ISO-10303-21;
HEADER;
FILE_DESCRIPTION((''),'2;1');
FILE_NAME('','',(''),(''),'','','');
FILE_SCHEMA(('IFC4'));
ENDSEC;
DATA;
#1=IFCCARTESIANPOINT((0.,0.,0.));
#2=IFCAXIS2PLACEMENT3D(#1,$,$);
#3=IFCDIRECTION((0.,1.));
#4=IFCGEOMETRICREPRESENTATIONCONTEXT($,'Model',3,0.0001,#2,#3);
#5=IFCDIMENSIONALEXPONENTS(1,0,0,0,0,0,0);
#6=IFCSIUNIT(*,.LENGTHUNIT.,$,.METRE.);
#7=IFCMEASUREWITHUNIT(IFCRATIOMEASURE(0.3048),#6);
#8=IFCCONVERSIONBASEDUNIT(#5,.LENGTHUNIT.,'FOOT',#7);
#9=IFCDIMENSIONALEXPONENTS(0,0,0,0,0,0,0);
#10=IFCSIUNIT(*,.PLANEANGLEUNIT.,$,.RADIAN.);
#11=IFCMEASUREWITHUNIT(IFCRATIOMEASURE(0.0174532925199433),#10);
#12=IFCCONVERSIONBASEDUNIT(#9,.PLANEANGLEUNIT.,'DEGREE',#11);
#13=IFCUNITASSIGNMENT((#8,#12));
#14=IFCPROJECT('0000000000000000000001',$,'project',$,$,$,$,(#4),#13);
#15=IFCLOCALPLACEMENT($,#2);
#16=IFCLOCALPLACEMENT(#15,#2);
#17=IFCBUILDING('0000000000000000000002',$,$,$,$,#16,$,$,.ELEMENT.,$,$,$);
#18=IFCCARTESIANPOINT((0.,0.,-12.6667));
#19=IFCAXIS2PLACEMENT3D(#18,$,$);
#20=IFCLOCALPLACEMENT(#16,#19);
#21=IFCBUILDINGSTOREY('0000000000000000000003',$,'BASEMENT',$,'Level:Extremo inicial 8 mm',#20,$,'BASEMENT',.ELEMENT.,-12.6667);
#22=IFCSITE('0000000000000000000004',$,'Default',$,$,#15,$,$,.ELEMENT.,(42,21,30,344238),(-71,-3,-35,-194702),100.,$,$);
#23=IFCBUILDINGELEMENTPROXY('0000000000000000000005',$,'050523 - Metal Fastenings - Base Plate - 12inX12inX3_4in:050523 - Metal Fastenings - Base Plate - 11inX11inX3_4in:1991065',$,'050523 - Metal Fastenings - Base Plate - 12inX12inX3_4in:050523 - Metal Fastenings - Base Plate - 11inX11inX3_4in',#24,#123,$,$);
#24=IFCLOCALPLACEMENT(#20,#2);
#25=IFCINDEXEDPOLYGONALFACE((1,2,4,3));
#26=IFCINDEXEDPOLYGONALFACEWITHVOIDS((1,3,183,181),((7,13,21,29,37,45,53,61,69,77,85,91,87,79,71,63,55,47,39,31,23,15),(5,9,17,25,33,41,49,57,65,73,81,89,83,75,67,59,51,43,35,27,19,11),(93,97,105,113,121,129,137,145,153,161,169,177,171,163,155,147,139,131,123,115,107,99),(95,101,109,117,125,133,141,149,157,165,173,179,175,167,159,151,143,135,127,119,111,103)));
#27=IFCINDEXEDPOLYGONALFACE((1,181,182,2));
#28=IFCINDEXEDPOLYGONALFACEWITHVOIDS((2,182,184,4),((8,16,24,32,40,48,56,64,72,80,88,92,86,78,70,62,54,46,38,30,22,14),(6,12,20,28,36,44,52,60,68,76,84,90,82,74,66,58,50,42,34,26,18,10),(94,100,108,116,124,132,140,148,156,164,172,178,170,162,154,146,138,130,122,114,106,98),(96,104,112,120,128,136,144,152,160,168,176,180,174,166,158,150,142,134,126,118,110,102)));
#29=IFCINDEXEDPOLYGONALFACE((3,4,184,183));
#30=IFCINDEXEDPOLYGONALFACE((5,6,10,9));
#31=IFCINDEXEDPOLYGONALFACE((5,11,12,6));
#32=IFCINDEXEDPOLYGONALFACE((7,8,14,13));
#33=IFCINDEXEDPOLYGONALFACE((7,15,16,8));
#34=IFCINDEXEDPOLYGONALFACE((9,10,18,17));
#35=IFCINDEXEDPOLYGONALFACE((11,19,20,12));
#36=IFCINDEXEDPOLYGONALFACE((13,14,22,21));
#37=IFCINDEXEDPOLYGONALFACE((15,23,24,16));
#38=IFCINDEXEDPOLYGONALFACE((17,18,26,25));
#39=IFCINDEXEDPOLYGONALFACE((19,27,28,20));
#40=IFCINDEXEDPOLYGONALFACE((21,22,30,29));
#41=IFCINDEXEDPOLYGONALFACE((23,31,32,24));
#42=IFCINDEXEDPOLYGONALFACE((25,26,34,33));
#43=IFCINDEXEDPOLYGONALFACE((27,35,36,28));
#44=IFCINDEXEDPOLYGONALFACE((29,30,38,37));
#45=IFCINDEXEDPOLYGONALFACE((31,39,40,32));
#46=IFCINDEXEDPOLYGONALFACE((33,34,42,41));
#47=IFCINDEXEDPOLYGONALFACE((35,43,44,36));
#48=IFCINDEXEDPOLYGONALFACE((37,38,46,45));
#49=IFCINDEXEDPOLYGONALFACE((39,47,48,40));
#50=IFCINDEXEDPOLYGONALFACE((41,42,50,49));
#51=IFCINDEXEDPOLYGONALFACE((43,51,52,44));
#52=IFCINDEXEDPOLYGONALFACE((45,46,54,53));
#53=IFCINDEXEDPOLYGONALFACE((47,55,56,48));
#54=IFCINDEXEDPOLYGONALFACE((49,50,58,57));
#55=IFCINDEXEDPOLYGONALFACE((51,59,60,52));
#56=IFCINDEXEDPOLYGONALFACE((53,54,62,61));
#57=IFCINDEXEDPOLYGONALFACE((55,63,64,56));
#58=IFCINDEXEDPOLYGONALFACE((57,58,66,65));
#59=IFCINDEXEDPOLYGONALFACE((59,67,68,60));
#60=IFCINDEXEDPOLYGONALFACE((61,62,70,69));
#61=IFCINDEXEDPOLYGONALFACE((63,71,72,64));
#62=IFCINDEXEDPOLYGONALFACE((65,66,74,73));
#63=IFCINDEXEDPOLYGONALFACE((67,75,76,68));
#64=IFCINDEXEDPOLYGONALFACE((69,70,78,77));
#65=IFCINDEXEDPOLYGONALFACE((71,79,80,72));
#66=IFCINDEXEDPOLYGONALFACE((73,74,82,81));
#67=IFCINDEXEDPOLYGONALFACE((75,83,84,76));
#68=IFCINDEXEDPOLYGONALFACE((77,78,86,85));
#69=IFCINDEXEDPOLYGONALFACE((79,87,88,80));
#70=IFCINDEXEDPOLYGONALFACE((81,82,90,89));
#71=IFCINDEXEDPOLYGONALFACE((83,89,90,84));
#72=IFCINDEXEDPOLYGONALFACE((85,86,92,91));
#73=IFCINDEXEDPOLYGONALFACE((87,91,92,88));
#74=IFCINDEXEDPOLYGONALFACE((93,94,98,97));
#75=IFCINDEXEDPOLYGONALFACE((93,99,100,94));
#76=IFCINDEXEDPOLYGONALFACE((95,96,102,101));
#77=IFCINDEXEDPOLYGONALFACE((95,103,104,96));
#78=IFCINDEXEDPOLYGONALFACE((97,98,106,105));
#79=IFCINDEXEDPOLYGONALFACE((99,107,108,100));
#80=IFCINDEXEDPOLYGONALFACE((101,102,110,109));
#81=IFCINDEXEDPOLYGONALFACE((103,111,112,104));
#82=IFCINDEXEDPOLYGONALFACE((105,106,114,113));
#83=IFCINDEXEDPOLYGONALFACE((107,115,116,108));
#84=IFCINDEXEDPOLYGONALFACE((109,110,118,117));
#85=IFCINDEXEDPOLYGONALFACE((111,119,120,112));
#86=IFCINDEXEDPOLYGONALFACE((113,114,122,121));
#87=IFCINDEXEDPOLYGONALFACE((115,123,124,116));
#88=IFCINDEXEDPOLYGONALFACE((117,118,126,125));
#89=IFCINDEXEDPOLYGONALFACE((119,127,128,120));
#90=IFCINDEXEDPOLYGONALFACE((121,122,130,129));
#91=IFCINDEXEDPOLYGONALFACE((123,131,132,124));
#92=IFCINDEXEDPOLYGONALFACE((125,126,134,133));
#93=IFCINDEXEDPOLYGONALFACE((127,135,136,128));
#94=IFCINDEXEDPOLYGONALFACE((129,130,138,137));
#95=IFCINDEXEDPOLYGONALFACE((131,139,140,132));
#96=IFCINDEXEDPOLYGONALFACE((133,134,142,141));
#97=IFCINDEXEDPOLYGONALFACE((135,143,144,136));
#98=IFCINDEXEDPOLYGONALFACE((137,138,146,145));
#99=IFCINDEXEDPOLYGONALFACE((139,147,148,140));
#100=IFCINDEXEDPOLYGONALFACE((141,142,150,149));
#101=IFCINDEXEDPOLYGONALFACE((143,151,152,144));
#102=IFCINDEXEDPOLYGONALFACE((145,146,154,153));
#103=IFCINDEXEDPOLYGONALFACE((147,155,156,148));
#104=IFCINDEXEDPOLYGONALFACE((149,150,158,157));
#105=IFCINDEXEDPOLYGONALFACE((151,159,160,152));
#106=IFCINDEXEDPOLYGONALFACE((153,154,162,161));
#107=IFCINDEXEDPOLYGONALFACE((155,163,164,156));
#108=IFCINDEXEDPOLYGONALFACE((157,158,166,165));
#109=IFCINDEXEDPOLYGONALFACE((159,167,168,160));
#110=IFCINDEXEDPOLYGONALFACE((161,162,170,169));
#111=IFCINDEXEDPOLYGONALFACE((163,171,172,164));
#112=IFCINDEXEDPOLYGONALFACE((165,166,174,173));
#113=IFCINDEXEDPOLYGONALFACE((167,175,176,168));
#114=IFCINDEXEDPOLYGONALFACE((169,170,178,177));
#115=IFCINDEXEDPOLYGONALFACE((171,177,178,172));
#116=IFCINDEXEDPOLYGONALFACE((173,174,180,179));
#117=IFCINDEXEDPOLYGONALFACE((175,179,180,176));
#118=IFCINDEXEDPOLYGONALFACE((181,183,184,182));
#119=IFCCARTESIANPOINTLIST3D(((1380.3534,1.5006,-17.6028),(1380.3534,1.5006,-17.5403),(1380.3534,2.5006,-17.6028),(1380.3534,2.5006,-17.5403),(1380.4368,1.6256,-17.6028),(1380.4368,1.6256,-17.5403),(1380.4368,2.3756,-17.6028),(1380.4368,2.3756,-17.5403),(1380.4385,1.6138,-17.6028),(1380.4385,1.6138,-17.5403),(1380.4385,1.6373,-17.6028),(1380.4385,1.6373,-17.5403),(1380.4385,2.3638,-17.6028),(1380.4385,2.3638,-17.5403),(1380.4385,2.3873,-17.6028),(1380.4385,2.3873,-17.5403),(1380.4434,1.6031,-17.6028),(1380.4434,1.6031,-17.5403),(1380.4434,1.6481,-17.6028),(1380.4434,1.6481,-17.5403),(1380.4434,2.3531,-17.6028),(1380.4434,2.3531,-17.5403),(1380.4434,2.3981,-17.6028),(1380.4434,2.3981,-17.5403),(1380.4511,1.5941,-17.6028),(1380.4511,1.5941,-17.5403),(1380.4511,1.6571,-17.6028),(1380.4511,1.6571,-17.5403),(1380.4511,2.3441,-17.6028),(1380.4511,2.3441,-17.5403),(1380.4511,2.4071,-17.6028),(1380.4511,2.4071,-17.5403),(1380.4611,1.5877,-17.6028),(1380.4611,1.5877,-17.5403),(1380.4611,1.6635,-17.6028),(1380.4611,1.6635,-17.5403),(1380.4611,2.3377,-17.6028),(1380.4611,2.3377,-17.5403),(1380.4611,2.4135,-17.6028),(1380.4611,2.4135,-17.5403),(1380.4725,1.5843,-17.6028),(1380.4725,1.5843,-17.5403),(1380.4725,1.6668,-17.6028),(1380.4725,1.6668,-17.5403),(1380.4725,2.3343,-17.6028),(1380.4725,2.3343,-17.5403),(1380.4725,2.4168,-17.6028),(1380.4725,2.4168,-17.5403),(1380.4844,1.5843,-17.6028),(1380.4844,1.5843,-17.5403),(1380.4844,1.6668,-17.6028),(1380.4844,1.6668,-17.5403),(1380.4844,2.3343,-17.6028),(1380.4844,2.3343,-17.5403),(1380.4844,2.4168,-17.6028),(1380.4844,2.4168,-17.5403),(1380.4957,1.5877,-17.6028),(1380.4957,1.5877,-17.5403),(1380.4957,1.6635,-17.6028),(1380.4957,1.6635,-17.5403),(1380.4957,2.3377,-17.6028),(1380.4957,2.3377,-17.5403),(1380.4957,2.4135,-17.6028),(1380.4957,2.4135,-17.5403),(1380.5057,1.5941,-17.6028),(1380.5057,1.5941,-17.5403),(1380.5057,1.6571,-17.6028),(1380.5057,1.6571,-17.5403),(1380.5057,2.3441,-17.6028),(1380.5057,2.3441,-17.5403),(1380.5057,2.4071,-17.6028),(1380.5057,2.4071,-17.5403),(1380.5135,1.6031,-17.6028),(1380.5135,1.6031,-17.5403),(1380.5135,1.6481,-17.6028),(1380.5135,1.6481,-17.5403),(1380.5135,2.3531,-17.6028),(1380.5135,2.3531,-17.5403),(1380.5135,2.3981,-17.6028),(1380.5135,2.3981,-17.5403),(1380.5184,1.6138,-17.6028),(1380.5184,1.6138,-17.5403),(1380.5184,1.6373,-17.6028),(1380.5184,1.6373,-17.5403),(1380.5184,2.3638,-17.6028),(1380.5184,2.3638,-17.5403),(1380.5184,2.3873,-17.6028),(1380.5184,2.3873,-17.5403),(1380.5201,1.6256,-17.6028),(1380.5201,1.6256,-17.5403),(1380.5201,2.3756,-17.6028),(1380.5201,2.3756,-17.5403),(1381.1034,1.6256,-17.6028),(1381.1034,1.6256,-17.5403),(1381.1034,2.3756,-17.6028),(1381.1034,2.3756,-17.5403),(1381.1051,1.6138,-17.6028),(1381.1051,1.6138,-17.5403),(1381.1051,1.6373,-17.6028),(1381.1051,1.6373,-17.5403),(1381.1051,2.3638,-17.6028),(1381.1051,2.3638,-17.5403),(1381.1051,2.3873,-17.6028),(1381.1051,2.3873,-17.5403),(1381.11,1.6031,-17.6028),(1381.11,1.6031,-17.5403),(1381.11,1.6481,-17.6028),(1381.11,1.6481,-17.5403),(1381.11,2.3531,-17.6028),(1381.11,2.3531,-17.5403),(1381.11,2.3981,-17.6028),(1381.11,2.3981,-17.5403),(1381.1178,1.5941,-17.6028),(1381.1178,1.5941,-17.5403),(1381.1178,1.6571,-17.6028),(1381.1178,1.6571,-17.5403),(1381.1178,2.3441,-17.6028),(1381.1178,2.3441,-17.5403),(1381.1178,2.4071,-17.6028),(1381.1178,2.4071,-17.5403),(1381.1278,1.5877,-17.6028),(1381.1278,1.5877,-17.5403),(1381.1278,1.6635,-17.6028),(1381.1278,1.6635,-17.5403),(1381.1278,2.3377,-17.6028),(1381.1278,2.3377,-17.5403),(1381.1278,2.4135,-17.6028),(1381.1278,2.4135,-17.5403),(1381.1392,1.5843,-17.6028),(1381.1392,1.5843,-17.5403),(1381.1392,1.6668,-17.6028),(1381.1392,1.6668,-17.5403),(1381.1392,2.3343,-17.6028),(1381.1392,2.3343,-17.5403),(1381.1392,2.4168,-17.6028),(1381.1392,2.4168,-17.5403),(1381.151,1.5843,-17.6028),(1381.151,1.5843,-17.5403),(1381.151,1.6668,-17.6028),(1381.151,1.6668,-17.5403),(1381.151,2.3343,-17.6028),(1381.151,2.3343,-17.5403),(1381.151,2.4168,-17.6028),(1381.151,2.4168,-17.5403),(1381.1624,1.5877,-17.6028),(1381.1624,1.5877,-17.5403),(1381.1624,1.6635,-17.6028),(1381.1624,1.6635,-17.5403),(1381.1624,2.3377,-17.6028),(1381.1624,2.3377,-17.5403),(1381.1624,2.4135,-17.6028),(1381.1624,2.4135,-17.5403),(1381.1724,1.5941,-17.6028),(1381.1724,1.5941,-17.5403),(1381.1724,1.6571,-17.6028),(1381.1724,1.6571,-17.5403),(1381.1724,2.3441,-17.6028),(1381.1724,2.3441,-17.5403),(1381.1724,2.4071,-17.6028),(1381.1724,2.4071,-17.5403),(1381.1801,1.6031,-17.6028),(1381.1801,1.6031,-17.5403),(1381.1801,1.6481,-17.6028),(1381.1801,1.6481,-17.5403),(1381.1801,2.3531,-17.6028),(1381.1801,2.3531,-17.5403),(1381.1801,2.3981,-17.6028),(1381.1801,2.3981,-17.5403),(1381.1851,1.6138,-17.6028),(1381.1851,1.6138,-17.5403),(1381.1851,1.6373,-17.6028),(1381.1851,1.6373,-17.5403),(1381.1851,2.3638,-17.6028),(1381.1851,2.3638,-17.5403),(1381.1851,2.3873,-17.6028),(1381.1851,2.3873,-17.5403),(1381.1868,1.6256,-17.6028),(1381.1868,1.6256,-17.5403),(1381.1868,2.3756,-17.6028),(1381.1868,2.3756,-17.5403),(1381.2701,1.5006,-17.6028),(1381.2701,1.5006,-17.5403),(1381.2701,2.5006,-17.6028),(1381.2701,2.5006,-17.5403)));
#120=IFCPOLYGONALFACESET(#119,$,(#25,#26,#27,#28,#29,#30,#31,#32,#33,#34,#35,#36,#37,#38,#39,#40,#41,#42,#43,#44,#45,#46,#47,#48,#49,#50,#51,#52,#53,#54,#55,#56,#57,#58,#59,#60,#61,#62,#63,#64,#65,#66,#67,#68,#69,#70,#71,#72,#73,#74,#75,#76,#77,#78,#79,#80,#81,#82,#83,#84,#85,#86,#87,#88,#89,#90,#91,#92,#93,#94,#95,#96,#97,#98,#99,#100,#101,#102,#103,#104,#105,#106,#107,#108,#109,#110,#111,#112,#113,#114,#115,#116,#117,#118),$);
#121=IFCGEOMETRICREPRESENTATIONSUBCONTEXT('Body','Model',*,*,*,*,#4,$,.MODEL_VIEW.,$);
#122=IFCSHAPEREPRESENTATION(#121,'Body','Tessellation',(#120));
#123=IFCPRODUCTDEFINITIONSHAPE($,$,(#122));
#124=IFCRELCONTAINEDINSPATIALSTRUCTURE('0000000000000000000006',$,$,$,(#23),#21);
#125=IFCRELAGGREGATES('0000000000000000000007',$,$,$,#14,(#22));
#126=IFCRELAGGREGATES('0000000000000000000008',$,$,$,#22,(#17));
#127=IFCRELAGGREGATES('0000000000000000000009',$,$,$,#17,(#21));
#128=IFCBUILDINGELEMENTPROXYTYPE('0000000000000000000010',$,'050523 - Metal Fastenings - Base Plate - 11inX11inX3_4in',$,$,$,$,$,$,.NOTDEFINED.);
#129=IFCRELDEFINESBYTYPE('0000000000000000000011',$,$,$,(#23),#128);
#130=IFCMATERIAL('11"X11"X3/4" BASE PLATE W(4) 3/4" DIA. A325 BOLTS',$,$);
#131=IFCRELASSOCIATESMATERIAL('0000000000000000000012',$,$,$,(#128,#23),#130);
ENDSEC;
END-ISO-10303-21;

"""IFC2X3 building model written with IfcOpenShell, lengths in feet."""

from ifc_helpers import new_model, entity, si_unit, converted_unit, direction, frame, frame_2d, origin, place, context, subcontext, project, spatial, polyline, circle_curve, parameter, trimmed, segment, composite_curve, outline, extrude, source, transform, mapped, material, type_object, type_shapes, element, save


model = new_model("IFC2X3")

# Units and contexts
model_context = context("Model", 3, precision=0.0001, world=origin(), true_north=direction((0.0, 1.0)))
body_context = subcontext(model_context, "Body", "Model", "MODEL_VIEW")
ifc_project = project(units=[converted_unit("LENGTHUNIT", "FOOT", entity("IfcRatioMeasure", 0.3048), si_unit("LENGTHUNIT", "METRE"), dimensions=[1, 0, 0, 0, 0, 0, 0]), converted_unit("PLANEANGLEUNIT", "DEGREE", entity("IfcRatioMeasure", 0.0174532925199433), si_unit("PLANEANGLEUNIT", "RADIAN"), dimensions=[0, 0, 0, 0, 0, 0, 0])], contexts=[model_context])

# Site, building, storey
site_placement = place(None, origin())
site = spatial("IfcSite", under=ifc_project, at=site_placement, Name="Default", CompositionType="ELEMENT", RefLatitude=(42, 21, 30, 344238), RefLongitude=(-71, -3, -35, -194702), RefElevation=100.0)
building_placement = place(site_placement, origin())
building = spatial("IfcBuilding", under=site, at=building_placement, CompositionType="ELEMENT")
storey_placement = place(building_placement, frame((0.0, 0.0, -12.6667)))
storey = spatial("IfcBuildingStorey", under=building, at=storey_placement, Name="BASEMENT", ObjectType="Level:Extremo inicial 8 mm", LongName="BASEMENT", CompositionType="ELEMENT", Elevation=-12.6667)

# Building element proxy
ifc_material_1 = material(Name="11\"X11\"X3/4\" BASE PLATE W(4) 3/4\" DIA. A325 BOLTS")
building_element_proxy_type_1 = type_object("IfcBuildingElementProxyType", Name="050523 - Metal Fastenings - Base Plate - 11inX11inX3_4in", PredefinedType="NOTDEFINED", material=ifc_material_1)
shared_shape_1 = source(origin(), body_context, "Body", "SweptSolid", [
    extrude(outline(polyline([(-0.4583, -0.5), (0.4583, -0.5), (0.4583, 0.5), (-0.4583, 0.5), (-0.4583, -0.5)]), holes=[composite_curve([segment(trimmed(circle_curve(frame_2d((-0.3333, -0.375), x_axis=(-1.0, 0.0)), 0.0417), [parameter(180.0)], [parameter(0.0)], True, "PARAMETER"), False, "CONTINUOUS"), segment(trimmed(circle_curve(frame_2d((-0.3333, -0.375), x_axis=(-1.0, 0.0)), 0.0417), [parameter(0.0)], [parameter(180.0)], True, "PARAMETER"), False, "CONTINUOUS")], self_intersect=False), composite_curve([segment(trimmed(circle_curve(frame_2d((0.3333, -0.375), x_axis=(-1.0, 0.0)), 0.0417), [parameter(180.0)], [parameter(0.0)], True, "PARAMETER"), False, "CONTINUOUS"), segment(trimmed(circle_curve(frame_2d((0.3333, -0.375), x_axis=(-1.0, 0.0)), 0.0417), [parameter(0.0)], [parameter(180.0)], True, "PARAMETER"), False, "CONTINUOUS")], self_intersect=False), composite_curve([segment(trimmed(circle_curve(frame_2d((-0.3333, 0.375), x_axis=(-1.0, 0.0)), 0.0417), [parameter(180.0)], [parameter(0.0)], True, "PARAMETER"), False, "CONTINUOUS"), segment(trimmed(circle_curve(frame_2d((-0.3333, 0.375), x_axis=(-1.0, 0.0)), 0.0417), [parameter(0.0)], [parameter(180.0)], True, "PARAMETER"), False, "CONTINUOUS")], self_intersect=False), composite_curve([segment(trimmed(circle_curve(frame_2d((0.3333, 0.375), x_axis=(-1.0, 0.0)), 0.0417), [parameter(180.0)], [parameter(0.0)], True, "PARAMETER"), False, "CONTINUOUS"), segment(trimmed(circle_curve(frame_2d((0.3333, 0.375), x_axis=(-1.0, 0.0)), 0.0417), [parameter(0.0)], [parameter(180.0)], True, "PARAMETER"), False, "CONTINUOUS")], self_intersect=False)]), frame((0.0, 0.0, 0.0), z_axis=(0.0, 0.0, 1.0), x_axis=(-1.0, 0.0, 0.0)), (0.0, 0.0, 1.0), 0.0625),
])
type_shapes(building_element_proxy_type_1, [shared_shape_1])
proxy_1_placement = place(storey_placement, frame((1380.8118, 2.0006, -17.6028)))
element("IfcBuildingElementProxy", 1, at=proxy_1_placement, inside=storey, type_object=building_element_proxy_type_1, material=ifc_material_1, Name="050523 - Metal Fastenings - Base Plate - 12inX12inX3_4in:050523 - Metal Fastenings - Base Plate - 11inX11inX3_4in:1991065", ObjectType="050523 - Metal Fastenings - Base Plate - 12inX12inX3_4in:050523 - Metal Fastenings - Base Plate - 11inX11inX3_4in", context=body_context, shape_type="MappedRepresentation", body=[
    mapped(shared_shape_1, transform((0.0, 0.0, 0.0), scale=1.0)),
])

save(model, "model.ifc")
